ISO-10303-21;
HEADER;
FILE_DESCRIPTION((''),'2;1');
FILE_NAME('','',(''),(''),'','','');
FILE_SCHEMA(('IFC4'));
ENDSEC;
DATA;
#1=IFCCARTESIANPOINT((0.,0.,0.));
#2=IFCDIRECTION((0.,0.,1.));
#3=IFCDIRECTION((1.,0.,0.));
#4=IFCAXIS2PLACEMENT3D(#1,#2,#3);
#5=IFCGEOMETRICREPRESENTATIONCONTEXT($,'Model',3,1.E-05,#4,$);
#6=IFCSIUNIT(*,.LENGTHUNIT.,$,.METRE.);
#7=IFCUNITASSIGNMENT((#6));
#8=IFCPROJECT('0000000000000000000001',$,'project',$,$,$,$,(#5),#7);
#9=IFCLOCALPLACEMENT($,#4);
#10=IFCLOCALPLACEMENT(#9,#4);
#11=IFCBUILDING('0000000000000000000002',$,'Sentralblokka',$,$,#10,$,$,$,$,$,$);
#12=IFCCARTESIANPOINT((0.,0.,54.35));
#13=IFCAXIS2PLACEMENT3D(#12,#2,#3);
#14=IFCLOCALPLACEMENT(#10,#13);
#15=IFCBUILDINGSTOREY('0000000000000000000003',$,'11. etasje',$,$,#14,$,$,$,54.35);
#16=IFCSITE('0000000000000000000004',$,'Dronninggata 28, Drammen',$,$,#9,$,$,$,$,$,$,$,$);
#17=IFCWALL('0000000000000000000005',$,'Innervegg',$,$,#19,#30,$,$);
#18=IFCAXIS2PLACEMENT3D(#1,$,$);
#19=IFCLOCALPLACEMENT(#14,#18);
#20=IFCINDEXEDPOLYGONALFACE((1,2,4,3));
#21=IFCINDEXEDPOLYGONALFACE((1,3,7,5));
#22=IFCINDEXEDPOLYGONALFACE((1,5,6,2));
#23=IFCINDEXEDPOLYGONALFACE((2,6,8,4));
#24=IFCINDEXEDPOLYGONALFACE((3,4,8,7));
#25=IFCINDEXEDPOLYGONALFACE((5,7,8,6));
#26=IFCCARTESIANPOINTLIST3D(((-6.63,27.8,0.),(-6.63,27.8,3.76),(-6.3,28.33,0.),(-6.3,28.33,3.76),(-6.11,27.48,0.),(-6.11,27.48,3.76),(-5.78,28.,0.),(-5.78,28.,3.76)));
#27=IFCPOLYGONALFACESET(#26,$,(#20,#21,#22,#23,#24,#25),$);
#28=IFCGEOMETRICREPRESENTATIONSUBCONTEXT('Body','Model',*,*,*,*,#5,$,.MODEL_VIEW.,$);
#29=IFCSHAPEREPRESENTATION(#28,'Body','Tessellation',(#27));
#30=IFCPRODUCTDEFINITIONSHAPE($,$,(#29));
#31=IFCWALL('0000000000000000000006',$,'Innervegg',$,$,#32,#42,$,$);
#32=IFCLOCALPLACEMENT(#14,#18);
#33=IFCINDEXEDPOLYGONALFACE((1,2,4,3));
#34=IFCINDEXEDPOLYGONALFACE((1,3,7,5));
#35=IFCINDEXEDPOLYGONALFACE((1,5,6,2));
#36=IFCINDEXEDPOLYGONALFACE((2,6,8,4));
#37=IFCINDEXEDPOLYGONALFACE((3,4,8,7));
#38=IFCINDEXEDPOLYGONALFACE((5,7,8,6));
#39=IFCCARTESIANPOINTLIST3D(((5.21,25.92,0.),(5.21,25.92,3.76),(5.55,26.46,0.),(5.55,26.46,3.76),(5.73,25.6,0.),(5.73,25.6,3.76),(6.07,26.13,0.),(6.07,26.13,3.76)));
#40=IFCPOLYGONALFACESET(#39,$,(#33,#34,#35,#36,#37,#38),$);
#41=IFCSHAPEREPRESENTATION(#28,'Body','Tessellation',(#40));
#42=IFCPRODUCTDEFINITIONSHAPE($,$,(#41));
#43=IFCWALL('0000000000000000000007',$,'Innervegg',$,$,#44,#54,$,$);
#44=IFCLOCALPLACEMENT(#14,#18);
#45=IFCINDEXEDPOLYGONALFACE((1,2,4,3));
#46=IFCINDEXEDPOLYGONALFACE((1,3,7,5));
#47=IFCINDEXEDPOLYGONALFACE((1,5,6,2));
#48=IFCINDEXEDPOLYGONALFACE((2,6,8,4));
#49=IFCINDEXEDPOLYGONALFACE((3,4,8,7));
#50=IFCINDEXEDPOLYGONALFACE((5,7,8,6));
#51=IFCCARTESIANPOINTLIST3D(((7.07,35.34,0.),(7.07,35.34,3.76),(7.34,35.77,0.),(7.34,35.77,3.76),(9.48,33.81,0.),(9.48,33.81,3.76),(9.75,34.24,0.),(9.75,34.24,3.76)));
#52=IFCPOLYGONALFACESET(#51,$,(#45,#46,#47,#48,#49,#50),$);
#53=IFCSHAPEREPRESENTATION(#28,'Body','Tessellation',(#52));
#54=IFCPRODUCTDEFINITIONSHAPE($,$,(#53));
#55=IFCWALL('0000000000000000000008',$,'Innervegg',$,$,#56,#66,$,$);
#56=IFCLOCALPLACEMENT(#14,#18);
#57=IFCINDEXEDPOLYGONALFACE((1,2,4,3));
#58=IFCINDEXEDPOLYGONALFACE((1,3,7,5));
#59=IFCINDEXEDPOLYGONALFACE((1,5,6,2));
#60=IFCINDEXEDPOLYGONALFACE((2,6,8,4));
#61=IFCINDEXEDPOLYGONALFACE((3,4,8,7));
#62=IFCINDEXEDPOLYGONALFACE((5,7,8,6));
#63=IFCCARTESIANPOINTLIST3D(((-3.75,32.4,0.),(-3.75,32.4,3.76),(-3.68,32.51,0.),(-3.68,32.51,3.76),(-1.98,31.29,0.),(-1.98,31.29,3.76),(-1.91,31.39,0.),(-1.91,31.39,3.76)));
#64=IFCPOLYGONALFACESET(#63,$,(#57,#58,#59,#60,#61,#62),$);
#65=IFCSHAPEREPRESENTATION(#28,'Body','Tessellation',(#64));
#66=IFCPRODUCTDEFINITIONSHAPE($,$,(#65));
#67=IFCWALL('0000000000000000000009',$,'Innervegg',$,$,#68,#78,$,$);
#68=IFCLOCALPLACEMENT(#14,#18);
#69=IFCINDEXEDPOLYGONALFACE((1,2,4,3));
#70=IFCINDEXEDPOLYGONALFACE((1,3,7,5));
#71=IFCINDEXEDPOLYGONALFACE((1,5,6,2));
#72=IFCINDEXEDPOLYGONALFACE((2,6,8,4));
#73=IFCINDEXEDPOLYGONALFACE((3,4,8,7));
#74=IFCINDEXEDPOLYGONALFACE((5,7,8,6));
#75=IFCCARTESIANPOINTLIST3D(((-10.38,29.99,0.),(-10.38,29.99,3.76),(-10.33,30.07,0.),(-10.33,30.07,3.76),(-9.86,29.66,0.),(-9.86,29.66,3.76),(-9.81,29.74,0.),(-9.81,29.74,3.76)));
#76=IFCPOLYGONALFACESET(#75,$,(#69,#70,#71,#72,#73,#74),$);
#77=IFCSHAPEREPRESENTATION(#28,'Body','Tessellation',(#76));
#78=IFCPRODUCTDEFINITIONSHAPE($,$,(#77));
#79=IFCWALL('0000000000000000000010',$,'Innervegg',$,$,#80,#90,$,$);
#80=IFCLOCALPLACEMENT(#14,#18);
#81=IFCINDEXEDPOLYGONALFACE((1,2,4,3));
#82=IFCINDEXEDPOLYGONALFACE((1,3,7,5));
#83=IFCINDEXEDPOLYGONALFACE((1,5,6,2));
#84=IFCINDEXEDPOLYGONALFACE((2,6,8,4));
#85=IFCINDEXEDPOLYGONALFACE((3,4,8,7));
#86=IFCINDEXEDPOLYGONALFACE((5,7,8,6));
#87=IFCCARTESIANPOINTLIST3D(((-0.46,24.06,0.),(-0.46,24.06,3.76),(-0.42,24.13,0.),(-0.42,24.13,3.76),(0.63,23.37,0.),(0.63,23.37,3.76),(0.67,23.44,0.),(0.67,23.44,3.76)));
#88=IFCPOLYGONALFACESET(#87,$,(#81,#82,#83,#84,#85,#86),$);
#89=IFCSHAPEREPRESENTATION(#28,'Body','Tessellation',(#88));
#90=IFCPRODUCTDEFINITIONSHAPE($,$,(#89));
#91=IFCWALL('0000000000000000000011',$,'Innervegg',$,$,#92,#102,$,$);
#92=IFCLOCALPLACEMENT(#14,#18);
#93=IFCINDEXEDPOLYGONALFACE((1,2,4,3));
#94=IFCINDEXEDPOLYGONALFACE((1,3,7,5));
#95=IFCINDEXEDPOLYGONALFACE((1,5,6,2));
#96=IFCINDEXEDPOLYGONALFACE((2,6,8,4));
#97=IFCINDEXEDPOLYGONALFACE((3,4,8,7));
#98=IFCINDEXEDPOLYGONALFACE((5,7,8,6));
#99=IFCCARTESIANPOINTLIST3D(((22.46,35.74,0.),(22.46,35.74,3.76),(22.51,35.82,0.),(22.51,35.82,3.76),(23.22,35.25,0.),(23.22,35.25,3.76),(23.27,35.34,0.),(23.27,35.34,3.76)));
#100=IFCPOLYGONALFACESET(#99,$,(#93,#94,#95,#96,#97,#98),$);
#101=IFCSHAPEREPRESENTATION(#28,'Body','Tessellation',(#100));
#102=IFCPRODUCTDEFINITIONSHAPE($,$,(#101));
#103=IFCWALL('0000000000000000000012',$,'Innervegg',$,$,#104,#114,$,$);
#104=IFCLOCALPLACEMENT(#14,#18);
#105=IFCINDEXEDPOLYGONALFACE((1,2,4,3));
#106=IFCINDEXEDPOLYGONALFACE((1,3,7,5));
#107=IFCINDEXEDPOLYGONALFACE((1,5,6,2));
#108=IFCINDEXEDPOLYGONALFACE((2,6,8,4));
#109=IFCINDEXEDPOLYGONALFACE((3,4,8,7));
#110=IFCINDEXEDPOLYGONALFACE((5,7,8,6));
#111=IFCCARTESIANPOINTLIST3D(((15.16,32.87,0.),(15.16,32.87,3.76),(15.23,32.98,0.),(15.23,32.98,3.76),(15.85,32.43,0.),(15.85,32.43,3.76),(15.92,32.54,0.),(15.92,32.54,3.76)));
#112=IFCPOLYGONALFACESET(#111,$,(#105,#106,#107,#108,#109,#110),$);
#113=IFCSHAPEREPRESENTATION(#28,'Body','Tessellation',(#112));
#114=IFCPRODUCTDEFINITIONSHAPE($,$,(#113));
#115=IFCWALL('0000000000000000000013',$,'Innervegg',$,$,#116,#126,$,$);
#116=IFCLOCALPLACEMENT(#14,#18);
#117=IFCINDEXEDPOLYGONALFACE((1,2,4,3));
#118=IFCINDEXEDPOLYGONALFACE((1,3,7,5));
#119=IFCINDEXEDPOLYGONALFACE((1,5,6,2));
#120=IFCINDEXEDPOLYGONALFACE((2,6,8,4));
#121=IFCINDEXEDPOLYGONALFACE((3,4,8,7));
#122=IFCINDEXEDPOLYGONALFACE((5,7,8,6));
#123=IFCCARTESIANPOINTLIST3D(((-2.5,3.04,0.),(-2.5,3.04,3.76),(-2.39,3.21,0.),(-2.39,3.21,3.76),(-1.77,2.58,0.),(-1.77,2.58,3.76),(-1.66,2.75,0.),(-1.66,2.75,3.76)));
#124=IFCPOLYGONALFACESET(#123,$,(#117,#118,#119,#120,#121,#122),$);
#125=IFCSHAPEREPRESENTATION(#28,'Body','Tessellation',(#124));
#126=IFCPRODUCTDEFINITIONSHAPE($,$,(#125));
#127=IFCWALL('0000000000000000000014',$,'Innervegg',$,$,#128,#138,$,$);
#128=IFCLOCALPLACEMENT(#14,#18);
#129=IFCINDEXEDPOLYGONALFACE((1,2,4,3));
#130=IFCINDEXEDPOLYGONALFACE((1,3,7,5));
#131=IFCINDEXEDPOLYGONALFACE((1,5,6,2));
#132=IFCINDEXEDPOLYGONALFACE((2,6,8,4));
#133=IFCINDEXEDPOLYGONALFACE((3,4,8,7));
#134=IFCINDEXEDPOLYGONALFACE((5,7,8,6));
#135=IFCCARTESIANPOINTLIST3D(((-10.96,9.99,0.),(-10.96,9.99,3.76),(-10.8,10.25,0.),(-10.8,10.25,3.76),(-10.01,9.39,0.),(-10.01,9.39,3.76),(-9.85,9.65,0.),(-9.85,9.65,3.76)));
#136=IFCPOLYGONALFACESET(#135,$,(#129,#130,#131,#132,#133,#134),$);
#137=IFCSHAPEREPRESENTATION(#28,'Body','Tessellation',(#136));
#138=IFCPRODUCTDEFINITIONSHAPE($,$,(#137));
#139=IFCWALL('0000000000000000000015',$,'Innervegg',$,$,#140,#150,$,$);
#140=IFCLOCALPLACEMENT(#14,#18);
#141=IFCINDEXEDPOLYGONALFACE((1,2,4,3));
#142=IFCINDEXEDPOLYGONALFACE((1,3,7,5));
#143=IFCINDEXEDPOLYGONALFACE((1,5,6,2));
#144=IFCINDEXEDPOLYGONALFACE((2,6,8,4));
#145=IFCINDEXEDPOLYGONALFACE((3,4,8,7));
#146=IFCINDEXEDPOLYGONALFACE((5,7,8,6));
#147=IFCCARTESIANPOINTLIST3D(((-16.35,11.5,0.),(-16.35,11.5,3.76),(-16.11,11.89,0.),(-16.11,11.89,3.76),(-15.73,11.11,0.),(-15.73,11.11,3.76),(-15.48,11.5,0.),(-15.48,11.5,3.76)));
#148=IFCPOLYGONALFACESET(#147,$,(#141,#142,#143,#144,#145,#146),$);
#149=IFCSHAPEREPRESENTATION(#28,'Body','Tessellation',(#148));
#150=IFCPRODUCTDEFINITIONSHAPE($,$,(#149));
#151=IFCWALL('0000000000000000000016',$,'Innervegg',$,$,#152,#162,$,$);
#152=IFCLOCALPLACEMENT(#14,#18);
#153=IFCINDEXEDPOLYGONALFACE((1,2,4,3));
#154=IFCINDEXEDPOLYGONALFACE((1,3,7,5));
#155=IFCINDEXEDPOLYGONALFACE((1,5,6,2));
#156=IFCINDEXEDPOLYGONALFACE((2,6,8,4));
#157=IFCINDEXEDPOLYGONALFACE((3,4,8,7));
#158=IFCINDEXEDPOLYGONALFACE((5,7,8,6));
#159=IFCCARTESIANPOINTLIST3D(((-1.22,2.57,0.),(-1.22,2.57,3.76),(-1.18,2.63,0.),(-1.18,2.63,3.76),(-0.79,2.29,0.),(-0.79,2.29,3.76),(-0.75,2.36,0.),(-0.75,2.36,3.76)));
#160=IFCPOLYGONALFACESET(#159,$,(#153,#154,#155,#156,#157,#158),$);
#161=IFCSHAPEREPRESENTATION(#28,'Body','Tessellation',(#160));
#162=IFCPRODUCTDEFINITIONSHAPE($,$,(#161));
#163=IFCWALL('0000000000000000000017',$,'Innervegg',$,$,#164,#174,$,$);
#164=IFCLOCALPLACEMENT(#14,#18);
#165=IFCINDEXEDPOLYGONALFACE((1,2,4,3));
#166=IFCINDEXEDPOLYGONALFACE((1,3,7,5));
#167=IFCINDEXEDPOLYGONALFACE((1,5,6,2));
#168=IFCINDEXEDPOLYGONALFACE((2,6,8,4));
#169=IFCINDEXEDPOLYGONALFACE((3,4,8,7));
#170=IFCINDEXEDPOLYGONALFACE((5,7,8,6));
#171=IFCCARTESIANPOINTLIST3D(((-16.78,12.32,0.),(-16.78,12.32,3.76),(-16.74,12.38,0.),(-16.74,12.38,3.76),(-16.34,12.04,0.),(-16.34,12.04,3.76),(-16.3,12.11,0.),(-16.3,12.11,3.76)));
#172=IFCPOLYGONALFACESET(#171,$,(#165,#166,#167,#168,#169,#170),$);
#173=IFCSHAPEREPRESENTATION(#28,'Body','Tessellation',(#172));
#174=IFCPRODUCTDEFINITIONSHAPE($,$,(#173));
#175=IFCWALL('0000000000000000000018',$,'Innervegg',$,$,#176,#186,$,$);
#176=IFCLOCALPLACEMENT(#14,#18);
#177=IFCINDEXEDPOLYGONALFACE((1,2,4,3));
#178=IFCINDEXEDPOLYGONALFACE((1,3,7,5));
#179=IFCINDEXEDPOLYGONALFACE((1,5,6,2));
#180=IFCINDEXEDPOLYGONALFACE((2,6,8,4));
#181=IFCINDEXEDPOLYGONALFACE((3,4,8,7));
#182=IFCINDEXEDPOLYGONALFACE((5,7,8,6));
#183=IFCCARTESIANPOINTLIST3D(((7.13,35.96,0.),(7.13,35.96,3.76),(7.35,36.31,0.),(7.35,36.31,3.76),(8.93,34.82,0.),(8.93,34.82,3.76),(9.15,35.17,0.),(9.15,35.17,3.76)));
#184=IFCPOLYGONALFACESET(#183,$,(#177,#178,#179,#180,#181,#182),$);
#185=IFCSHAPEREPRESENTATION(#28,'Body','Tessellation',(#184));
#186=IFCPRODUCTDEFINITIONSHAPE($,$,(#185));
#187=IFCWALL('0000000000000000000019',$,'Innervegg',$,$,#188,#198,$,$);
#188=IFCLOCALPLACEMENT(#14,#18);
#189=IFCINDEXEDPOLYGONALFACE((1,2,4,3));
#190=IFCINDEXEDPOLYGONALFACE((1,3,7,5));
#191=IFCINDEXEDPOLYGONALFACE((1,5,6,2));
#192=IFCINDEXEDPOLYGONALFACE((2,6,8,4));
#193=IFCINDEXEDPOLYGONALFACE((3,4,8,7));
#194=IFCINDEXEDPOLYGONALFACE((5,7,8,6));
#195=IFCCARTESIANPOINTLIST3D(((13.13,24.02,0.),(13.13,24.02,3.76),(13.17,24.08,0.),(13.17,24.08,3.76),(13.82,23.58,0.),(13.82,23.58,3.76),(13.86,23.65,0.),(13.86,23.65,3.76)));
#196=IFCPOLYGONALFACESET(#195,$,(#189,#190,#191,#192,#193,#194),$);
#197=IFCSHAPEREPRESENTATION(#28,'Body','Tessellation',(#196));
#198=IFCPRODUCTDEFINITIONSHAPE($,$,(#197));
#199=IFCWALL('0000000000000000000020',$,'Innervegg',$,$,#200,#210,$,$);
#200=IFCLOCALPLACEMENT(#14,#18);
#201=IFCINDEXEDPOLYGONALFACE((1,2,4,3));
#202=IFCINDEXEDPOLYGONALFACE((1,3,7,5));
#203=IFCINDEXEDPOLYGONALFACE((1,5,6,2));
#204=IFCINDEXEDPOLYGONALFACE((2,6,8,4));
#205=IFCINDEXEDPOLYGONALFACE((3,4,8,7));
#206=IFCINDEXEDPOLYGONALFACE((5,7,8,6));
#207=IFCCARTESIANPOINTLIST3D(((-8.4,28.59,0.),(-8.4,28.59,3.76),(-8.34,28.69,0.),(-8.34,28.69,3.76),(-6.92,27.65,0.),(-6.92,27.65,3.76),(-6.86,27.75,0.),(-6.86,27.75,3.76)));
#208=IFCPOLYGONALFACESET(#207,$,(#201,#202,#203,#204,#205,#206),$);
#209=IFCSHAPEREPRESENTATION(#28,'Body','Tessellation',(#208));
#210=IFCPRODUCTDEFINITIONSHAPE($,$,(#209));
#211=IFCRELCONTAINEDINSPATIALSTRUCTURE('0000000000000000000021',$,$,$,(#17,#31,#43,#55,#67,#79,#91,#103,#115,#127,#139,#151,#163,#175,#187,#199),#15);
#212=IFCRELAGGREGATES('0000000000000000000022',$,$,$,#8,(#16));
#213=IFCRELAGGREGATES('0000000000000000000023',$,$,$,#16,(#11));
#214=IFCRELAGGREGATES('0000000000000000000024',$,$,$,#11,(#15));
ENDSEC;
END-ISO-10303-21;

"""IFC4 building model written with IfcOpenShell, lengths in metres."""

from ifc_helpers import new_model, si_unit, frame, origin_with_axes, place, context, subcontext, project, spatial, polyline, outline, extrude, element, save


model = new_model("IFC4")

# Units and contexts
model_context = context("Model", 3, precision=1e-05, world=origin_with_axes())
body_context = subcontext(model_context, "Body", "Model", "MODEL_VIEW")
ifc_project = project(units=[si_unit("LENGTHUNIT", "METRE")], contexts=[model_context])

# Site, building, storey
site_placement = place(None, origin_with_axes())
site = spatial("IfcSite", under=ifc_project, at=site_placement, Name="Dronninggata 28, Drammen")
building_placement = place(site_placement, origin_with_axes())
building = spatial("IfcBuilding", under=site, at=building_placement, Name="Sentralblokka")
storey_placement = place(building_placement, frame((0.0, 0.0, 54.35), z_axis=(0.0, 0.0, 1.0), x_axis=(1.0, 0.0, 0.0)))
storey = spatial("IfcBuildingStorey", under=building, at=storey_placement, Name="11. etasje", Elevation=54.35)

# Walls
wall_1_placement = place(storey_placement, frame((0.0, 0.0, -54.35), z_axis=(0.0, 0.0, 1.0), x_axis=(1.0, 0.0, 0.0)))
element("IfcWall", 1, at=wall_1_placement, inside=storey, Name="Innervegg", context=body_context, shape_type="SweptSolid", body=[
    extrude(outline(polyline([(-5.78, 28.0), (-6.11, 27.48), (-6.63, 27.8), (-6.3, 28.33), (-5.78, 28.0)])), frame((0.0, 0.0, 54.35)), (0.0, 0.0, 1.0), 3.76),
])
wall_2_placement = place(storey_placement, frame((0.0, 0.0, -54.35), z_axis=(0.0, 0.0, 1.0), x_axis=(1.0, 0.0, 0.0)))
element("IfcWall", 2, at=wall_2_placement, inside=storey, Name="Innervegg", context=body_context, shape_type="SweptSolid", body=[
    extrude(outline(polyline([(6.07, 26.13), (5.73, 25.6), (5.21, 25.92), (5.55, 26.46), (6.07, 26.13)])), frame((0.0, 0.0, 54.35)), (0.0, 0.0, 1.0), 3.76),
])
wall_3_placement = place(storey_placement, frame((0.0, 0.0, -54.35), z_axis=(0.0, 0.0, 1.0), x_axis=(1.0, 0.0, 0.0)))
element("IfcWall", 3, at=wall_3_placement, inside=storey, Name="Innervegg", context=body_context, shape_type="SweptSolid", body=[
    extrude(outline(polyline([(9.75, 34.24), (9.48, 33.81), (7.07, 35.34), (7.34, 35.77), (9.75, 34.24)])), frame((0.0, 0.0, 54.35)), (0.0, 0.0, 1.0), 3.76),
])
wall_4_placement = place(storey_placement, frame((0.0, 0.0, -54.35), z_axis=(0.0, 0.0, 1.0), x_axis=(1.0, 0.0, 0.0)))
element("IfcWall", 4, at=wall_4_placement, inside=storey, Name="Innervegg", context=body_context, shape_type="SweptSolid", body=[
    extrude(outline(polyline([(-1.91, 31.39), (-1.98, 31.29), (-3.75, 32.4), (-3.68, 32.51), (-1.91, 31.39)])), frame((0.0, 0.0, 54.35)), (0.0, 0.0, 1.0), 3.76),
])
wall_5_placement = place(storey_placement, frame((0.0, 0.0, -54.35), z_axis=(0.0, 0.0, 1.0), x_axis=(1.0, 0.0, 0.0)))
element("IfcWall", 5, at=wall_5_placement, inside=storey, Name="Innervegg", context=body_context, shape_type="SweptSolid", body=[
    extrude(outline(polyline([(-9.81, 29.74), (-9.86, 29.66), (-10.38, 29.99), (-10.33, 30.07), (-9.81, 29.74)])), frame((0.0, 0.0, 54.35)), (0.0, 0.0, 1.0), 3.76),
])
wall_6_placement = place(storey_placement, frame((0.0, 0.0, -54.35), z_axis=(0.0, 0.0, 1.0), x_axis=(1.0, 0.0, 0.0)))
element("IfcWall", 6, at=wall_6_placement, inside=storey, Name="Innervegg", context=body_context, shape_type="SweptSolid", body=[
    extrude(outline(polyline([(0.67, 23.44), (0.63, 23.37), (-0.46, 24.06), (-0.42, 24.13), (0.67, 23.44)])), frame((0.0, 0.0, 54.35)), (0.0, 0.0, 1.0), 3.76),
])
wall_7_placement = place(storey_placement, frame((0.0, 0.0, -54.35), z_axis=(0.0, 0.0, 1.0), x_axis=(1.0, 0.0, 0.0)))
element("IfcWall", 7, at=wall_7_placement, inside=storey, Name="Innervegg", context=body_context, shape_type="SweptSolid", body=[
    extrude(outline(polyline([(23.27, 35.34), (23.22, 35.25), (22.46, 35.74), (22.51, 35.82), (23.27, 35.34)])), frame((0.0, 0.0, 54.35)), (0.0, 0.0, 1.0), 3.76),
])
wall_8_placement = place(storey_placement, frame((0.0, 0.0, -54.35), z_axis=(0.0, 0.0, 1.0), x_axis=(1.0, 0.0, 0.0)))
element("IfcWall", 8, at=wall_8_placement, inside=storey, Name="Innervegg", context=body_context, shape_type="SweptSolid", body=[
    extrude(outline(polyline([(15.92, 32.54), (15.85, 32.43), (15.16, 32.87), (15.23, 32.98), (15.92, 32.54)])), frame((0.0, 0.0, 54.35)), (0.0, 0.0, 1.0), 3.76),
])
wall_9_placement = place(storey_placement, frame((0.0, 0.0, -54.35), z_axis=(0.0, 0.0, 1.0), x_axis=(1.0, 0.0, 0.0)))
element("IfcWall", 9, at=wall_9_placement, inside=storey, Name="Innervegg", context=body_context, shape_type="SweptSolid", body=[
    extrude(outline(polyline([(-1.66, 2.75), (-1.77, 2.58), (-2.5, 3.04), (-2.39, 3.21), (-1.66, 2.75)])), frame((0.0, 0.0, 54.35)), (0.0, 0.0, 1.0), 3.76),
])
wall_10_placement = place(storey_placement, frame((0.0, 0.0, -54.35), z_axis=(0.0, 0.0, 1.0), x_axis=(1.0, 0.0, 0.0)))
element("IfcWall", 10, at=wall_10_placement, inside=storey, Name="Innervegg", context=body_context, shape_type="SweptSolid", body=[
    extrude(outline(polyline([(-9.85, 9.65), (-10.01, 9.39), (-10.96, 9.99), (-10.8, 10.25), (-9.85, 9.65)])), frame((0.0, 0.0, 54.35)), (0.0, 0.0, 1.0), 3.76),
])
wall_11_placement = place(storey_placement, frame((0.0, 0.0, -54.35), z_axis=(0.0, 0.0, 1.0), x_axis=(1.0, 0.0, 0.0)))
element("IfcWall", 11, at=wall_11_placement, inside=storey, Name="Innervegg", context=body_context, shape_type="SweptSolid", body=[
    extrude(outline(polyline([(-15.48, 11.5), (-15.73, 11.11), (-16.35, 11.5), (-16.11, 11.89), (-15.48, 11.5)])), frame((0.0, 0.0, 54.35)), (0.0, 0.0, 1.0), 3.76),
])
wall_12_placement = place(storey_placement, frame((0.0, 0.0, -54.35), z_axis=(0.0, 0.0, 1.0), x_axis=(1.0, 0.0, 0.0)))
element("IfcWall", 12, at=wall_12_placement, inside=storey, Name="Innervegg", context=body_context, shape_type="SweptSolid", body=[
    extrude(outline(polyline([(-0.75, 2.36), (-0.79, 2.29), (-1.22, 2.57), (-1.18, 2.63), (-0.75, 2.36)])), frame((0.0, 0.0, 54.35)), (0.0, 0.0, 1.0), 3.76),
])
wall_13_placement = place(storey_placement, frame((0.0, 0.0, -54.35), z_axis=(0.0, 0.0, 1.0), x_axis=(1.0, 0.0, 0.0)))
element("IfcWall", 13, at=wall_13_placement, inside=storey, Name="Innervegg", context=body_context, shape_type="SweptSolid", body=[
    extrude(outline(polyline([(-16.3, 12.11), (-16.34, 12.04), (-16.78, 12.32), (-16.74, 12.38), (-16.3, 12.11)])), frame((0.0, 0.0, 54.35)), (0.0, 0.0, 1.0), 3.76),
])
wall_14_placement = place(storey_placement, frame((0.0, 0.0, -54.35), z_axis=(0.0, 0.0, 1.0), x_axis=(1.0, 0.0, 0.0)))
element("IfcWall", 14, at=wall_14_placement, inside=storey, Name="Innervegg", context=body_context, shape_type="SweptSolid", body=[
    extrude(outline(polyline([(9.15, 35.17), (8.93, 34.82), (7.13, 35.96), (7.35, 36.31), (9.15, 35.17)])), frame((0.0, 0.0, 54.35)), (0.0, 0.0, 1.0), 3.76),
])
wall_15_placement = place(storey_placement, frame((0.0, 0.0, -54.35), z_axis=(0.0, 0.0, 1.0), x_axis=(1.0, 0.0, 0.0)))
element("IfcWall", 15, at=wall_15_placement, inside=storey, Name="Innervegg", context=body_context, shape_type="SweptSolid", body=[
    extrude(outline(polyline([(13.86, 23.65), (13.82, 23.58), (13.13, 24.02), (13.17, 24.08), (13.86, 23.65)])), frame((0.0, 0.0, 54.35)), (0.0, 0.0, 1.0), 3.76),
])
wall_16_placement = place(storey_placement, frame((0.0, 0.0, -54.35), z_axis=(0.0, 0.0, 1.0), x_axis=(1.0, 0.0, 0.0)))
element("IfcWall", 16, at=wall_16_placement, inside=storey, Name="Innervegg", context=body_context, shape_type="SweptSolid", body=[
    extrude(outline(polyline([(-6.86, 27.75), (-6.92, 27.65), (-8.4, 28.59), (-8.34, 28.69), (-6.86, 27.75)])), frame((0.0, 0.0, 54.35)), (0.0, 0.0, 1.0), 3.76),
])

save(model, "model.ifc")
